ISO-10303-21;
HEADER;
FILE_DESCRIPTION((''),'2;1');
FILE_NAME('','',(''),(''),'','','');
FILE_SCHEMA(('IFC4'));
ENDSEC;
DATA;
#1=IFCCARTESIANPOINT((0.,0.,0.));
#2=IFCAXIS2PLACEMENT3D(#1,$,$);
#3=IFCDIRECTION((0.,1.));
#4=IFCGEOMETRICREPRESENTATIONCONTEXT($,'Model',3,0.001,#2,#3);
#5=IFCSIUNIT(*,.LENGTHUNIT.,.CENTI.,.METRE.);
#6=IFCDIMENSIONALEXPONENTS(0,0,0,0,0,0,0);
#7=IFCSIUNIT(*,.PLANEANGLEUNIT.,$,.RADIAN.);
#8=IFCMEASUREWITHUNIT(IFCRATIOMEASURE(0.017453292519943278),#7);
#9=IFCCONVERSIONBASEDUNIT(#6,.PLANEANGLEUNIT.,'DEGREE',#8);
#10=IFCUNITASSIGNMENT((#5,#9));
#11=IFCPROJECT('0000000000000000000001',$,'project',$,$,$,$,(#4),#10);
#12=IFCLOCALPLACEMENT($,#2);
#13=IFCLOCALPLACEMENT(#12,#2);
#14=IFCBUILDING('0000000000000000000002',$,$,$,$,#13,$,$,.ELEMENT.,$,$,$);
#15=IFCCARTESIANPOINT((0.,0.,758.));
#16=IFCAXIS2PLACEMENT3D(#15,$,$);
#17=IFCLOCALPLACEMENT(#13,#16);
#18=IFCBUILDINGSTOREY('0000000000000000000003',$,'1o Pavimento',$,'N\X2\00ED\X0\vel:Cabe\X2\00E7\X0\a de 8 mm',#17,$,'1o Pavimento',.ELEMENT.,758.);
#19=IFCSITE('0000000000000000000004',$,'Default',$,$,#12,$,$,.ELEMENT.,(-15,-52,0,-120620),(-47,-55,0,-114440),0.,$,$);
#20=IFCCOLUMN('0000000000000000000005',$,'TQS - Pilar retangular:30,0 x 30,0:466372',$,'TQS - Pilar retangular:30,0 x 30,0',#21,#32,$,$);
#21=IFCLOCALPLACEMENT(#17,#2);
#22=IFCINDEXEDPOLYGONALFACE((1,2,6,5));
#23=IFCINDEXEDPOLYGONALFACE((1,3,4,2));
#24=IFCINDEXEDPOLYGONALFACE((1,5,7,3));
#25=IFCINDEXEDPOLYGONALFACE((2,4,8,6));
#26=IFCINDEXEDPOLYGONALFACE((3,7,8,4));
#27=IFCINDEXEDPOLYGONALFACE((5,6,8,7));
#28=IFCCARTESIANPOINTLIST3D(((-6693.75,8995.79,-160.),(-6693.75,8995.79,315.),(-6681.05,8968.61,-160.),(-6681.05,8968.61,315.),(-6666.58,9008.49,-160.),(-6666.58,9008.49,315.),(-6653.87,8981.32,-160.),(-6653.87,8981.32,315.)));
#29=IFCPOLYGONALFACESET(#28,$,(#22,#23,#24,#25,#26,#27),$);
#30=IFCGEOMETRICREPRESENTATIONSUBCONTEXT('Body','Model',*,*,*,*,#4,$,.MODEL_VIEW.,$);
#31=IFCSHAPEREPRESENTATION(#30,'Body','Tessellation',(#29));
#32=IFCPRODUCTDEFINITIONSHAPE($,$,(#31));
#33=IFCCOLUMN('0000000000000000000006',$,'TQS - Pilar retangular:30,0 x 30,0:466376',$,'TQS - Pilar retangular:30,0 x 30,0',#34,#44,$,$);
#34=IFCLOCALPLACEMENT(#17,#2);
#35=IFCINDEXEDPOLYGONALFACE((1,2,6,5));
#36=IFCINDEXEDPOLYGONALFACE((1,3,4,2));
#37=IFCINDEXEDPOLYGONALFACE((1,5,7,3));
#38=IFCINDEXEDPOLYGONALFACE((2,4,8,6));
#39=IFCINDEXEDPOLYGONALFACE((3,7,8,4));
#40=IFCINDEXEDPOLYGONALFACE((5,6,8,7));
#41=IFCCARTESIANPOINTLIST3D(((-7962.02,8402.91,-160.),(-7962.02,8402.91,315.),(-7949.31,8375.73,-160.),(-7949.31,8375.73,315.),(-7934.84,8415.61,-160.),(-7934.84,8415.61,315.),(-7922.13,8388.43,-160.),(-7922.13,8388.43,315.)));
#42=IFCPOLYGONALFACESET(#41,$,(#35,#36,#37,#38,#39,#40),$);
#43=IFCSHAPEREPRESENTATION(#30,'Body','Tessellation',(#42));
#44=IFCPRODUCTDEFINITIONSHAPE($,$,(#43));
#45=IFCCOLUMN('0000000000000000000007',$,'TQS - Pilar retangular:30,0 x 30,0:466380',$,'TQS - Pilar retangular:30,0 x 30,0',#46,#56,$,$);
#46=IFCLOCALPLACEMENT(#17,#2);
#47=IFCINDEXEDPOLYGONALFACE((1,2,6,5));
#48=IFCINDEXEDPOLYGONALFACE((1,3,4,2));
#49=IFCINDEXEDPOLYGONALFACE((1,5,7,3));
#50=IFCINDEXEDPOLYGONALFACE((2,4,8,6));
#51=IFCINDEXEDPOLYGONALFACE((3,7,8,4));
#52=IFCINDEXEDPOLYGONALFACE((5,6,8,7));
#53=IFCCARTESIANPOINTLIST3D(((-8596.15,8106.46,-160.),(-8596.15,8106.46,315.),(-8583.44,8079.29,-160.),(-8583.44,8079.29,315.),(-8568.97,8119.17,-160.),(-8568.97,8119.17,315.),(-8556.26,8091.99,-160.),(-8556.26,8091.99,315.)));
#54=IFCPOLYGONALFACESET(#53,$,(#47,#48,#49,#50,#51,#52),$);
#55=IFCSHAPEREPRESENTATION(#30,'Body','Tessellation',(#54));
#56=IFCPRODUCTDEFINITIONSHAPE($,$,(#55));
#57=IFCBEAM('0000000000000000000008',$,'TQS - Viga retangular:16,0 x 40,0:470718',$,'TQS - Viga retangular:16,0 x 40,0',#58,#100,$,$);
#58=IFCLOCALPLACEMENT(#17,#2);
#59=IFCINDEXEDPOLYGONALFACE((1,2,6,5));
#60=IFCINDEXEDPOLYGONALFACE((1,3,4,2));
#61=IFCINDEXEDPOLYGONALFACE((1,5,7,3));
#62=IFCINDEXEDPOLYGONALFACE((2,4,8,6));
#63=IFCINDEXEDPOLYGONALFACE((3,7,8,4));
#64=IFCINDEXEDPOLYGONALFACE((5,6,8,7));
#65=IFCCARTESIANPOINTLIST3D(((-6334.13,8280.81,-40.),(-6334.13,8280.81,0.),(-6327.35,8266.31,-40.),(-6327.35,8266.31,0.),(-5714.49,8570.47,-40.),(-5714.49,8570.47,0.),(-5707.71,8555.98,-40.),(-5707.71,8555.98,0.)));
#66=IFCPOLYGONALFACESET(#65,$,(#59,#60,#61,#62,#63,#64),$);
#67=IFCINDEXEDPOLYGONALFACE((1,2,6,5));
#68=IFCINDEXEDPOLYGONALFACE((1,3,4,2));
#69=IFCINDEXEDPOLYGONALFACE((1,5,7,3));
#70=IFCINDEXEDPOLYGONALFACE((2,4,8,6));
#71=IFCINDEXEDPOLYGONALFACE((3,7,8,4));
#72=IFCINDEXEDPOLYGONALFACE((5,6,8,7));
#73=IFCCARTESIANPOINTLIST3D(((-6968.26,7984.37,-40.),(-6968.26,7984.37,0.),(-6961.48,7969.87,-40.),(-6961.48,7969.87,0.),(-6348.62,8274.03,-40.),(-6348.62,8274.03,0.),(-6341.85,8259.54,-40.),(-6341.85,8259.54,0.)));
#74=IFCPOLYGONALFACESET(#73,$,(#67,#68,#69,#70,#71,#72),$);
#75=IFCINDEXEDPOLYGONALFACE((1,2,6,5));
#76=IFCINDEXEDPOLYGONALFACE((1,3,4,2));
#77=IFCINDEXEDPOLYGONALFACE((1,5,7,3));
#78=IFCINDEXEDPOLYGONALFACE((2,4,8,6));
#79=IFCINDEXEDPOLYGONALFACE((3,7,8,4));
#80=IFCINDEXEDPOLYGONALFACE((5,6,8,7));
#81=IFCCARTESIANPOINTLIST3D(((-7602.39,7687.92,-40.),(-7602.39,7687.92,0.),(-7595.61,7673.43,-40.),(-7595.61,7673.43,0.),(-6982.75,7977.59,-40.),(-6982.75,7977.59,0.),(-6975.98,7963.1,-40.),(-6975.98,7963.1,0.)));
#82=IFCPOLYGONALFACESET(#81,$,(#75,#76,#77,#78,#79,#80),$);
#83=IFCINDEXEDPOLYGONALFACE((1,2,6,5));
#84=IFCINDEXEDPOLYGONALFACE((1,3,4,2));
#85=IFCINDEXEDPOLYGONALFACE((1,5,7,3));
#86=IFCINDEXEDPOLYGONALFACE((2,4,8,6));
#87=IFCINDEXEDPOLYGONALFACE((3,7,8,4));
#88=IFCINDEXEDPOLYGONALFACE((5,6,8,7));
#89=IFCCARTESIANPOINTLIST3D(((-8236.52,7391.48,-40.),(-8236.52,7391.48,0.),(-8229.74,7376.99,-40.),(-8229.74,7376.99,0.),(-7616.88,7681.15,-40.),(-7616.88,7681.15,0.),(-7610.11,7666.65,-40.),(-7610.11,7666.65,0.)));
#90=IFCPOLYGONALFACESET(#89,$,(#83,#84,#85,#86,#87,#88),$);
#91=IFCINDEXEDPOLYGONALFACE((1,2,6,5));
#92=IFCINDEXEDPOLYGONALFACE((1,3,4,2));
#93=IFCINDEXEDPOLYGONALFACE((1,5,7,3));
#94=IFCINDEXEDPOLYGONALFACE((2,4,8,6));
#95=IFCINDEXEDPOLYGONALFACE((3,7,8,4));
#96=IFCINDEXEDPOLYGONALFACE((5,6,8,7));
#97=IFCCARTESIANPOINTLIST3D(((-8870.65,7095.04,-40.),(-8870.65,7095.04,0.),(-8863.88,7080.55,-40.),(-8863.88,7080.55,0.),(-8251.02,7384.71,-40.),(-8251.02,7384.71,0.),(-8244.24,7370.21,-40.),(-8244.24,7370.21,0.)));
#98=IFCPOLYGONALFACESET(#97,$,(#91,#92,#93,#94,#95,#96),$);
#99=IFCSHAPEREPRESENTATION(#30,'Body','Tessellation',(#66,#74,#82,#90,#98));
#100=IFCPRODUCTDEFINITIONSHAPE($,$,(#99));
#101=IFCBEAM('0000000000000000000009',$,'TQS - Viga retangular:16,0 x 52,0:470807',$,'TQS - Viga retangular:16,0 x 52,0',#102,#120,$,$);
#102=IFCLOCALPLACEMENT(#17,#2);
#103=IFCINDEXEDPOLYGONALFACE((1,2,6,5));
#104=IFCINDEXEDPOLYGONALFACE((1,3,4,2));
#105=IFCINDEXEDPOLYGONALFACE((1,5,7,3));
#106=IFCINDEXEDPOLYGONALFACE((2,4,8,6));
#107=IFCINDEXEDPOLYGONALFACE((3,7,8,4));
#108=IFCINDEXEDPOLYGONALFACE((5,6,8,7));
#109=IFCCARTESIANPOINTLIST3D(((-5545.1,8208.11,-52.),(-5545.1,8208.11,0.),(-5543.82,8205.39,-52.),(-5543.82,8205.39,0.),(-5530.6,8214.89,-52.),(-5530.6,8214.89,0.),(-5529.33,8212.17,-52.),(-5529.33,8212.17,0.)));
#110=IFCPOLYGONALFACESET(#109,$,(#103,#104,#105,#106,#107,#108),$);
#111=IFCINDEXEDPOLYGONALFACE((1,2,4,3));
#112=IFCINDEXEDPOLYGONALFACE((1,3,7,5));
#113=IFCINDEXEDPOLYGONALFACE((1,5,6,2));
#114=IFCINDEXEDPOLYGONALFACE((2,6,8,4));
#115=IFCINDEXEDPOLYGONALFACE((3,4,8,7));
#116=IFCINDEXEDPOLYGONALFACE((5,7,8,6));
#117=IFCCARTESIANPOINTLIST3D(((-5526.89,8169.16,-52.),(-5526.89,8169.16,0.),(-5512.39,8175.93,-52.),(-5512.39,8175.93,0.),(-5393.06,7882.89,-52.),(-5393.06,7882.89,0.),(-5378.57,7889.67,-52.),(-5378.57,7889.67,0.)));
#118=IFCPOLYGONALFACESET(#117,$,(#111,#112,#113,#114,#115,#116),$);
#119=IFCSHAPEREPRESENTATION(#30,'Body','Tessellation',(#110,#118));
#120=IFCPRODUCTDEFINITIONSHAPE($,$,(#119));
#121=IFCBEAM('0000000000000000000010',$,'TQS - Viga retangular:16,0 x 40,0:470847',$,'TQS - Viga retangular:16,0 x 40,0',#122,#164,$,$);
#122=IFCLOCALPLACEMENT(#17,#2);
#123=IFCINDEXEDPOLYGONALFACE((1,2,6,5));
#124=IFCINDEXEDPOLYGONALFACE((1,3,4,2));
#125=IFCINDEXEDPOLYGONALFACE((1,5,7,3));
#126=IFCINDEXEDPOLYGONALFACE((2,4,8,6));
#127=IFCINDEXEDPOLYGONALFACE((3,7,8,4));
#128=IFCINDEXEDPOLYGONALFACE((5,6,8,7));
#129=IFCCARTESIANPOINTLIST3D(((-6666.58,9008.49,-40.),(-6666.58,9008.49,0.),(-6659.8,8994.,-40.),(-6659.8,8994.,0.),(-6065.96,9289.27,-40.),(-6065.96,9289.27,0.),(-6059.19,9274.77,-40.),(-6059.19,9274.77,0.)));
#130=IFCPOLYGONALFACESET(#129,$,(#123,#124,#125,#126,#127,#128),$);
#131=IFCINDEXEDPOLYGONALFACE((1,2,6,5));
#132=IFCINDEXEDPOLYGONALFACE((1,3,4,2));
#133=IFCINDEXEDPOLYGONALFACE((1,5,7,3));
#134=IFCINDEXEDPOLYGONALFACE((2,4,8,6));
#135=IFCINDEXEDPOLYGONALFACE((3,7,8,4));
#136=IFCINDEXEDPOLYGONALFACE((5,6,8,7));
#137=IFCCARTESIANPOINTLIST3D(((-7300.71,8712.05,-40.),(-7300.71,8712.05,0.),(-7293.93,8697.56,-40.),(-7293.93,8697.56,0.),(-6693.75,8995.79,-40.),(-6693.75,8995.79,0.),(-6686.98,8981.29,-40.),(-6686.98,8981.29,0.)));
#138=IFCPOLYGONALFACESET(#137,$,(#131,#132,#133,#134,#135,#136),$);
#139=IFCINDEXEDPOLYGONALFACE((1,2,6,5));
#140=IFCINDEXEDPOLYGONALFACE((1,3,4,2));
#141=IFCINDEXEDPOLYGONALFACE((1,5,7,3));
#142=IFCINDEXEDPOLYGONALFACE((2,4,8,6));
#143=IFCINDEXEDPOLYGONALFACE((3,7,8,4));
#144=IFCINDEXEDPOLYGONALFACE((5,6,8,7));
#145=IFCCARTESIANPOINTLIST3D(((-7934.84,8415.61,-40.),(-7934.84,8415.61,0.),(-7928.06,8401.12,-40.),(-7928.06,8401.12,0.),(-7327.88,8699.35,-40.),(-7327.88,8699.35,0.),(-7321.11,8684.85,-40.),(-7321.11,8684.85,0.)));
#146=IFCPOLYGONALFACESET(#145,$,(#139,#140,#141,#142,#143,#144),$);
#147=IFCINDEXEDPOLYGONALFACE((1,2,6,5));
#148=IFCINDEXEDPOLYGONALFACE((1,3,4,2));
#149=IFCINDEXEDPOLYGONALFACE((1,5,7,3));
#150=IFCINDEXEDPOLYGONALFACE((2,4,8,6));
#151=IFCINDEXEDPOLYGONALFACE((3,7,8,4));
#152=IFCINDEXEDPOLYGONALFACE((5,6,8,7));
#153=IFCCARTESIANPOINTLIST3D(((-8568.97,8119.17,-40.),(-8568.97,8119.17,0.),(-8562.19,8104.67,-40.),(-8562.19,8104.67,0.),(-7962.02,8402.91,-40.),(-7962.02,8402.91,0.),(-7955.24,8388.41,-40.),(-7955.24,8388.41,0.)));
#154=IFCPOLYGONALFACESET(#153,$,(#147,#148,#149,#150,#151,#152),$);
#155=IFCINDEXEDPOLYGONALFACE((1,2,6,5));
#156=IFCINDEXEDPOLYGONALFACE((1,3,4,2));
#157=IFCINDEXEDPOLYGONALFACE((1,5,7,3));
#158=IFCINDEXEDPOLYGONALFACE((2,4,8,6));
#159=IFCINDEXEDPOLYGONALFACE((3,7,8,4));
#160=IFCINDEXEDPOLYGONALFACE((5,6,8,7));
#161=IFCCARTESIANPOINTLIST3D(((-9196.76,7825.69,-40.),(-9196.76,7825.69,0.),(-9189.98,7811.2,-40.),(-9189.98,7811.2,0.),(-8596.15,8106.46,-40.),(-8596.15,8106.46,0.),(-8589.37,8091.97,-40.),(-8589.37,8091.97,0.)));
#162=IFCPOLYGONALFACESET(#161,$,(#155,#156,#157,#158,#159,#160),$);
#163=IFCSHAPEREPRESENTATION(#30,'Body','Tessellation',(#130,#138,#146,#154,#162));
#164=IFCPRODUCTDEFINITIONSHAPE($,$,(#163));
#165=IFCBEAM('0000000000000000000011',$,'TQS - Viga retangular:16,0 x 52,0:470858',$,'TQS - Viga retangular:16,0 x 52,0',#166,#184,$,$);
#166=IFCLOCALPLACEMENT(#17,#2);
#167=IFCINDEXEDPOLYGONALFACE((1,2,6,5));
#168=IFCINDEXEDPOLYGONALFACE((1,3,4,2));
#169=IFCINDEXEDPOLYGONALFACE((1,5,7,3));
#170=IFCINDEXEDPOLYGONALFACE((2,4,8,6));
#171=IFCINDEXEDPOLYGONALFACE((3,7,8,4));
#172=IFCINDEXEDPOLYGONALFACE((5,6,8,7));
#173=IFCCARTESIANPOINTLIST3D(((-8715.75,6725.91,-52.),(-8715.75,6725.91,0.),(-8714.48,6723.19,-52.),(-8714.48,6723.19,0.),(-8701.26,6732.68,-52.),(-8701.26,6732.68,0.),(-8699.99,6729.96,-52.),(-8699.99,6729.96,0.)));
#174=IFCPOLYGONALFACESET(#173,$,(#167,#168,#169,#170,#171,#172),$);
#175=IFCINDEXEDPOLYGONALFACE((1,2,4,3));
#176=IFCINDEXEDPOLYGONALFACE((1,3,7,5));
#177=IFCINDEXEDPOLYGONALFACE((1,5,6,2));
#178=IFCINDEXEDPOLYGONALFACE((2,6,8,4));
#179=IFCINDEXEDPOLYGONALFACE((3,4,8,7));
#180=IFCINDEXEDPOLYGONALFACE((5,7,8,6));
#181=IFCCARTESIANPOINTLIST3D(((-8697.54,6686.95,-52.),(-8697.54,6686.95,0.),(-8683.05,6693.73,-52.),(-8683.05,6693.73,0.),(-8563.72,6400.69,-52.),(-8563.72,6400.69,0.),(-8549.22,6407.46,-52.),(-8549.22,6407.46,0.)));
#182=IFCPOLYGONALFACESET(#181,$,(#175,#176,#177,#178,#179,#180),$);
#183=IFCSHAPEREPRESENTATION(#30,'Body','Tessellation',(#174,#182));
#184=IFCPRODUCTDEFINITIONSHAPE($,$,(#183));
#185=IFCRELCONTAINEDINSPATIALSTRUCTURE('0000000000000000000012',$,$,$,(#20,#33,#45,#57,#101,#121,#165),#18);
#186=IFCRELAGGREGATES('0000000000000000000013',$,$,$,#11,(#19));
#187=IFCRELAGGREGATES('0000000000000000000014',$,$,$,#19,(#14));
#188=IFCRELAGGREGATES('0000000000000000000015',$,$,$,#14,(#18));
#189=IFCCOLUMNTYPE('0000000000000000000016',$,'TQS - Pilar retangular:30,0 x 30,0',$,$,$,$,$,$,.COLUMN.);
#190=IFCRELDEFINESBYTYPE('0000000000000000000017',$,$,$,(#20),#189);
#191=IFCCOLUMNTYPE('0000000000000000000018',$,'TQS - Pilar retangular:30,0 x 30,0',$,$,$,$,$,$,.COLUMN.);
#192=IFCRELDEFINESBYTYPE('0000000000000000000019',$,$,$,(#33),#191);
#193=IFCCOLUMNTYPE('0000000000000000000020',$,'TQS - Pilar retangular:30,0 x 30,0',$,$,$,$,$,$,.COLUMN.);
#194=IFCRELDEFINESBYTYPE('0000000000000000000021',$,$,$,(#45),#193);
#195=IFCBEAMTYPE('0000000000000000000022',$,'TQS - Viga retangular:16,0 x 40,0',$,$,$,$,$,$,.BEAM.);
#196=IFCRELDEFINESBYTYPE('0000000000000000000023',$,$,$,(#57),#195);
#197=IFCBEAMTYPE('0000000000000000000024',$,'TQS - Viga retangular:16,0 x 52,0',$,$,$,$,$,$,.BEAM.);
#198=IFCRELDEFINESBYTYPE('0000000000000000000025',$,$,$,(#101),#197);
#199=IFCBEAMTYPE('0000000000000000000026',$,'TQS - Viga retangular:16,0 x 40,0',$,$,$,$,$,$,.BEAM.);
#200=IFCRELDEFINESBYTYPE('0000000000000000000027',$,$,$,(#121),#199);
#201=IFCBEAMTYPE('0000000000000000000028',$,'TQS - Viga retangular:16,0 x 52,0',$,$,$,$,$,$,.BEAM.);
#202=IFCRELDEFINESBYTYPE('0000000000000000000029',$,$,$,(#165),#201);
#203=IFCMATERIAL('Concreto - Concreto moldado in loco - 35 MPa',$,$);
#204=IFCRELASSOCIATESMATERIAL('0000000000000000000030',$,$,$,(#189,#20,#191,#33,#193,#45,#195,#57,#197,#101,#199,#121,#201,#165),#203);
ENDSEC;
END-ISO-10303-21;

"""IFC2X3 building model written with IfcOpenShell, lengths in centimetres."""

from ifc_helpers import new_model, entity, si_unit, converted_unit, direction, frame, frame_2d, origin, origin_2d_with_axis, place, context, subcontext, project, spatial, rectangle, extrude, source, transform, mapped, material, type_object, type_shapes, element, save


model = new_model("IFC2X3")

# Units and contexts
model_context = context("Model", 3, precision=0.001, world=origin(), true_north=direction((0.0, 1.0)))
body_context = subcontext(model_context, "Body", "Model", "MODEL_VIEW")
ifc_project = project(units=[si_unit("LENGTHUNIT", "METRE", prefix="CENTI"), converted_unit("PLANEANGLEUNIT", "DEGREE", entity("IfcRatioMeasure", 0.017453292519943278), si_unit("PLANEANGLEUNIT", "RADIAN"), dimensions=[0, 0, 0, 0, 0, 0, 0])], contexts=[model_context])

# Site, building, storey
site_placement = place(None, origin())
site = spatial("IfcSite", under=ifc_project, at=site_placement, Name="Default", CompositionType="ELEMENT", RefLatitude=(-15, -52, 0, -120620), RefLongitude=(-47, -55, 0, -114440), RefElevation=0.0)
building_placement = place(site_placement, origin())
building = spatial("IfcBuilding", under=site, at=building_placement, CompositionType="ELEMENT")
storey_placement = place(building_placement, frame((0.0, 0.0, 758.0)))
storey = spatial("IfcBuildingStorey", under=building, at=storey_placement, Name="1o Pavimento", ObjectType="Nível:Cabeça de 8 mm", LongName="1o Pavimento", CompositionType="ELEMENT", Elevation=758.0)

# Columns
ifc_material = material(Name="Concreto - Concreto moldado in loco - 35 MPa")
column_type_1 = type_object("IfcColumnType", Name="TQS - Pilar retangular:30,0 x 30,0", PredefinedType="COLUMN", material=ifc_material)
shared_shape_1 = source(origin(), body_context, "Body", "SweptSolid", [
    extrude(rectangle(XDim=30.0, YDim=30.0, at=origin_2d_with_axis()), frame((-6673.81, 8988.55, 598.0), z_axis=(0.0, 0.0, 1.0), x_axis=(-0.423488, 0.905902, 0.0)), (0.0, 0.0, 1.0), 475.0),
])
type_shapes(column_type_1, [shared_shape_1])
column_1_placement = place(storey_placement, frame((0.0, 0.0, -758.0)))
element("IfcColumn", 1, at=column_1_placement, inside=storey, type_object=column_type_1, material=ifc_material, Name="TQS - Pilar retangular:30,0 x 30,0:466372", ObjectType="TQS - Pilar retangular:30,0 x 30,0", context=body_context, shape_type="MappedRepresentation", body=[
    mapped(shared_shape_1, transform((0.0, 0.0, 0.0), scale=1.0)),
])
column_type_2 = type_object("IfcColumnType", Name="TQS - Pilar retangular:30,0 x 30,0", PredefinedType="COLUMN", material=ifc_material)
shared_shape_2 = source(origin(), body_context, "Body", "SweptSolid", [
    extrude(rectangle(XDim=30.0, YDim=30.0, at=origin_2d_with_axis()), frame((-7942.07, 8395.67, 598.0), z_axis=(0.0, 0.0, 1.0), x_axis=(-0.423488, 0.905902, 0.0)), (0.0, 0.0, 1.0), 475.0),
])
type_shapes(column_type_2, [shared_shape_2])
column_2_placement = place(storey_placement, frame((0.0, 0.0, -758.0)))
element("IfcColumn", 2, at=column_2_placement, inside=storey, type_object=column_type_2, material=ifc_material, Name="TQS - Pilar retangular:30,0 x 30,0:466376", ObjectType="TQS - Pilar retangular:30,0 x 30,0", context=body_context, shape_type="MappedRepresentation", body=[
    mapped(shared_shape_2, transform((0.0, 0.0, 0.0), scale=1.0)),
])
column_type_3 = type_object("IfcColumnType", Name="TQS - Pilar retangular:30,0 x 30,0", PredefinedType="COLUMN", material=ifc_material)
shared_shape_3 = source(origin(), body_context, "Body", "SweptSolid", [
    extrude(rectangle(XDim=30.0, YDim=30.0, at=origin_2d_with_axis()), frame((-8576.21, 8099.23, 598.0), z_axis=(0.0, 0.0, 1.0), x_axis=(-0.423488, 0.905902, 0.0)), (0.0, 0.0, 1.0), 475.0),
])
type_shapes(column_type_3, [shared_shape_3])
column_3_placement = place(storey_placement, frame((0.0, 0.0, -758.0)))
element("IfcColumn", 3, at=column_3_placement, inside=storey, type_object=column_type_3, material=ifc_material, Name="TQS - Pilar retangular:30,0 x 30,0:466380", ObjectType="TQS - Pilar retangular:30,0 x 30,0", context=body_context, shape_type="MappedRepresentation", body=[
    mapped(shared_shape_3, transform((0.0, 0.0, 0.0), scale=1.0)),
])

# Beams
beam_type_1 = type_object("IfcBeamType", Name="TQS - Viga retangular:16,0 x 40,0", PredefinedType="BEAM", material=ifc_material)
shared_shape_4 = source(origin(), body_context, "Body", "SweptSolid", [
    extrude(rectangle(XDim=40.0, YDim=16.0, at=frame_2d((0.0, 0.0), x_axis=(1.0, 0.0))), frame((-6330.74, 8273.56, 738.0), z_axis=(0.905902, 0.423488, 0.0), x_axis=(0.0, 0.0, 1.0)), (0.0, 0.0, 1.0), 684.0),
    extrude(rectangle(XDim=40.0, YDim=16.0, at=frame_2d((0.0, 0.0), x_axis=(1.0, 0.0))), frame((-6964.87, 7977.12, 738.0), z_axis=(0.905902, 0.423488, 0.0), x_axis=(0.0, 0.0, 1.0)), (0.0, 0.0, 1.0), 684.0),
    extrude(rectangle(XDim=40.0, YDim=16.0, at=frame_2d((0.0, 0.0), x_axis=(1.0, 0.0))), frame((-7599.0, 7680.68, 738.0), z_axis=(0.905902, 0.423488, 0.0), x_axis=(0.0, 0.0, 1.0)), (0.0, 0.0, 1.0), 684.0),
    extrude(rectangle(XDim=40.0, YDim=16.0, at=frame_2d((0.0, 0.0), x_axis=(1.0, 0.0))), frame((-8233.13, 7384.24, 738.0), z_axis=(0.905902, 0.423488, 0.0), x_axis=(0.0, 0.0, 1.0)), (0.0, 0.0, 1.0), 684.0),
    extrude(rectangle(XDim=40.0, YDim=16.0, at=frame_2d((0.0, 0.0), x_axis=(1.0, 0.0))), frame((-8867.26, 7087.79, 738.0), z_axis=(0.905902, 0.423488, 0.0), x_axis=(0.0, 0.0, 1.0)), (0.0, 0.0, 1.0), 684.0),
])
type_shapes(beam_type_1, [shared_shape_4])
beam_1_placement = place(storey_placement, frame((0.0, 0.0, -758.0)))
element("IfcBeam", 4, at=beam_1_placement, inside=storey, type_object=beam_type_1, material=ifc_material, Name="TQS - Viga retangular:16,0 x 40,0:470718", ObjectType="TQS - Viga retangular:16,0 x 40,0", context=body_context, shape_type="MappedRepresentation", body=[
    mapped(shared_shape_4, transform((0.0, 0.0, 0.0), scale=1.0)),
])
beam_type_2 = type_object("IfcBeamType", Name="TQS - Viga retangular:16,0 x 52,0", PredefinedType="BEAM", material=ifc_material)
shared_shape_5 = source(origin(), body_context, "Body", "SweptSolid", [
    extrude(rectangle(XDim=52.0, YDim=16.0, at=frame_2d((0.0, 0.0), x_axis=(1.0, 0.0))), frame((-5536.58, 8208.78, 732.0), z_axis=(-0.423488, 0.905902, 0.0), x_axis=(0.0, 0.0, 1.0)), (0.0, 0.0, 1.0), 3.0),
    extrude(rectangle(XDim=52.0, YDim=16.0, at=frame_2d((0.0, 0.0), x_axis=(1.0, 0.0))), frame((-5385.82, 7886.28, 732.0), z_axis=(-0.423488, 0.905902, 0.0), x_axis=(0.0, 0.0, 1.0)), (0.0, 0.0, 1.0), 316.0),
])
type_shapes(beam_type_2, [shared_shape_5])
beam_2_placement = place(storey_placement, frame((0.0, 0.0, -758.0)))
element("IfcBeam", 5, at=beam_2_placement, inside=storey, type_object=beam_type_2, material=ifc_material, Name="TQS - Viga retangular:16,0 x 52,0:470807", ObjectType="TQS - Viga retangular:16,0 x 52,0", context=body_context, shape_type="MappedRepresentation", body=[
    mapped(shared_shape_5, transform((0.0, 0.0, 0.0), scale=1.0)),
])
beam_type_3 = type_object("IfcBeamType", Name="TQS - Viga retangular:16,0 x 40,0", PredefinedType="BEAM", material=ifc_material)
shared_shape_6 = source(origin(), body_context, "Body", "SweptSolid", [
    extrude(rectangle(XDim=40.0, YDim=16.0, at=origin_2d_with_axis()), frame((-6663.19, 9001.25, 738.0), z_axis=(0.905902, 0.423488, 0.0), x_axis=(0.0, 0.0, 1.0)), (0.0, 0.0, 1.0), 663.0),
    extrude(rectangle(XDim=40.0, YDim=16.0, at=origin_2d_with_axis()), frame((-7297.32, 8704.8, 738.0), z_axis=(0.905902, 0.423488, 0.0), x_axis=(0.0, 0.0, 1.0)), (0.0, 0.0, 1.0), 670.0),
    extrude(rectangle(XDim=40.0, YDim=16.0, at=frame_2d((0.0, 0.0), x_axis=(1.0, 0.0))), frame((-7931.45, 8408.36, 738.0), z_axis=(0.905902, 0.423488, 0.0), x_axis=(0.0, 0.0, 1.0)), (0.0, 0.0, 1.0), 670.0),
    extrude(rectangle(XDim=40.0, YDim=16.0, at=origin_2d_with_axis()), frame((-8565.58, 8111.92, 738.0), z_axis=(0.905902, 0.423488, 0.0), x_axis=(0.0, 0.0, 1.0)), (0.0, 0.0, 1.0), 670.0),
    extrude(rectangle(XDim=40.0, YDim=16.0, at=frame_2d((0.0, 0.0), x_axis=(1.0, 0.0))), frame((-9193.37, 7818.44, 738.0), z_axis=(0.905902, 0.423488, 0.0), x_axis=(0.0, 0.0, 1.0)), (0.0, 0.0, 1.0), 663.0),
])
type_shapes(beam_type_3, [shared_shape_6])
beam_3_placement = place(storey_placement, frame((0.0, 0.0, -758.0)))
element("IfcBeam", 6, at=beam_3_placement, inside=storey, type_object=beam_type_3, material=ifc_material, Name="TQS - Viga retangular:16,0 x 40,0:470847", ObjectType="TQS - Viga retangular:16,0 x 40,0", context=body_context, shape_type="MappedRepresentation", body=[
    mapped(shared_shape_6, transform((0.0, 0.0, 0.0), scale=1.0)),
])
beam_type_4 = type_object("IfcBeamType", Name="TQS - Viga retangular:16,0 x 52,0", PredefinedType="BEAM", material=ifc_material)
shared_shape_7 = source(origin(), body_context, "Body", "SweptSolid", [
    extrude(rectangle(XDim=52.0, YDim=16.0, at=frame_2d((0.0, 0.0), x_axis=(1.0, 0.0))), frame((-8707.23, 6726.58, 732.0), z_axis=(-0.423488, 0.905902, 0.0), x_axis=(0.0, 0.0, 1.0)), (0.0, 0.0, 1.0), 3.0),
    extrude(rectangle(XDim=52.0, YDim=16.0, at=frame_2d((0.0, 0.0), x_axis=(1.0, 0.0))), frame((-8556.47, 6404.07, 732.0), z_axis=(-0.423488, 0.905902, 0.0), x_axis=(0.0, 0.0, 1.0)), (0.0, 0.0, 1.0), 316.0),
])
type_shapes(beam_type_4, [shared_shape_7])
beam_4_placement = place(storey_placement, frame((0.0, 0.0, -758.0)))
element("IfcBeam", 7, at=beam_4_placement, inside=storey, type_object=beam_type_4, material=ifc_material, Name="TQS - Viga retangular:16,0 x 52,0:470858", ObjectType="TQS - Viga retangular:16,0 x 52,0", context=body_context, shape_type="MappedRepresentation", body=[
    mapped(shared_shape_7, transform((0.0, 0.0, 0.0), scale=1.0)),
])

save(model, "model.ifc")
